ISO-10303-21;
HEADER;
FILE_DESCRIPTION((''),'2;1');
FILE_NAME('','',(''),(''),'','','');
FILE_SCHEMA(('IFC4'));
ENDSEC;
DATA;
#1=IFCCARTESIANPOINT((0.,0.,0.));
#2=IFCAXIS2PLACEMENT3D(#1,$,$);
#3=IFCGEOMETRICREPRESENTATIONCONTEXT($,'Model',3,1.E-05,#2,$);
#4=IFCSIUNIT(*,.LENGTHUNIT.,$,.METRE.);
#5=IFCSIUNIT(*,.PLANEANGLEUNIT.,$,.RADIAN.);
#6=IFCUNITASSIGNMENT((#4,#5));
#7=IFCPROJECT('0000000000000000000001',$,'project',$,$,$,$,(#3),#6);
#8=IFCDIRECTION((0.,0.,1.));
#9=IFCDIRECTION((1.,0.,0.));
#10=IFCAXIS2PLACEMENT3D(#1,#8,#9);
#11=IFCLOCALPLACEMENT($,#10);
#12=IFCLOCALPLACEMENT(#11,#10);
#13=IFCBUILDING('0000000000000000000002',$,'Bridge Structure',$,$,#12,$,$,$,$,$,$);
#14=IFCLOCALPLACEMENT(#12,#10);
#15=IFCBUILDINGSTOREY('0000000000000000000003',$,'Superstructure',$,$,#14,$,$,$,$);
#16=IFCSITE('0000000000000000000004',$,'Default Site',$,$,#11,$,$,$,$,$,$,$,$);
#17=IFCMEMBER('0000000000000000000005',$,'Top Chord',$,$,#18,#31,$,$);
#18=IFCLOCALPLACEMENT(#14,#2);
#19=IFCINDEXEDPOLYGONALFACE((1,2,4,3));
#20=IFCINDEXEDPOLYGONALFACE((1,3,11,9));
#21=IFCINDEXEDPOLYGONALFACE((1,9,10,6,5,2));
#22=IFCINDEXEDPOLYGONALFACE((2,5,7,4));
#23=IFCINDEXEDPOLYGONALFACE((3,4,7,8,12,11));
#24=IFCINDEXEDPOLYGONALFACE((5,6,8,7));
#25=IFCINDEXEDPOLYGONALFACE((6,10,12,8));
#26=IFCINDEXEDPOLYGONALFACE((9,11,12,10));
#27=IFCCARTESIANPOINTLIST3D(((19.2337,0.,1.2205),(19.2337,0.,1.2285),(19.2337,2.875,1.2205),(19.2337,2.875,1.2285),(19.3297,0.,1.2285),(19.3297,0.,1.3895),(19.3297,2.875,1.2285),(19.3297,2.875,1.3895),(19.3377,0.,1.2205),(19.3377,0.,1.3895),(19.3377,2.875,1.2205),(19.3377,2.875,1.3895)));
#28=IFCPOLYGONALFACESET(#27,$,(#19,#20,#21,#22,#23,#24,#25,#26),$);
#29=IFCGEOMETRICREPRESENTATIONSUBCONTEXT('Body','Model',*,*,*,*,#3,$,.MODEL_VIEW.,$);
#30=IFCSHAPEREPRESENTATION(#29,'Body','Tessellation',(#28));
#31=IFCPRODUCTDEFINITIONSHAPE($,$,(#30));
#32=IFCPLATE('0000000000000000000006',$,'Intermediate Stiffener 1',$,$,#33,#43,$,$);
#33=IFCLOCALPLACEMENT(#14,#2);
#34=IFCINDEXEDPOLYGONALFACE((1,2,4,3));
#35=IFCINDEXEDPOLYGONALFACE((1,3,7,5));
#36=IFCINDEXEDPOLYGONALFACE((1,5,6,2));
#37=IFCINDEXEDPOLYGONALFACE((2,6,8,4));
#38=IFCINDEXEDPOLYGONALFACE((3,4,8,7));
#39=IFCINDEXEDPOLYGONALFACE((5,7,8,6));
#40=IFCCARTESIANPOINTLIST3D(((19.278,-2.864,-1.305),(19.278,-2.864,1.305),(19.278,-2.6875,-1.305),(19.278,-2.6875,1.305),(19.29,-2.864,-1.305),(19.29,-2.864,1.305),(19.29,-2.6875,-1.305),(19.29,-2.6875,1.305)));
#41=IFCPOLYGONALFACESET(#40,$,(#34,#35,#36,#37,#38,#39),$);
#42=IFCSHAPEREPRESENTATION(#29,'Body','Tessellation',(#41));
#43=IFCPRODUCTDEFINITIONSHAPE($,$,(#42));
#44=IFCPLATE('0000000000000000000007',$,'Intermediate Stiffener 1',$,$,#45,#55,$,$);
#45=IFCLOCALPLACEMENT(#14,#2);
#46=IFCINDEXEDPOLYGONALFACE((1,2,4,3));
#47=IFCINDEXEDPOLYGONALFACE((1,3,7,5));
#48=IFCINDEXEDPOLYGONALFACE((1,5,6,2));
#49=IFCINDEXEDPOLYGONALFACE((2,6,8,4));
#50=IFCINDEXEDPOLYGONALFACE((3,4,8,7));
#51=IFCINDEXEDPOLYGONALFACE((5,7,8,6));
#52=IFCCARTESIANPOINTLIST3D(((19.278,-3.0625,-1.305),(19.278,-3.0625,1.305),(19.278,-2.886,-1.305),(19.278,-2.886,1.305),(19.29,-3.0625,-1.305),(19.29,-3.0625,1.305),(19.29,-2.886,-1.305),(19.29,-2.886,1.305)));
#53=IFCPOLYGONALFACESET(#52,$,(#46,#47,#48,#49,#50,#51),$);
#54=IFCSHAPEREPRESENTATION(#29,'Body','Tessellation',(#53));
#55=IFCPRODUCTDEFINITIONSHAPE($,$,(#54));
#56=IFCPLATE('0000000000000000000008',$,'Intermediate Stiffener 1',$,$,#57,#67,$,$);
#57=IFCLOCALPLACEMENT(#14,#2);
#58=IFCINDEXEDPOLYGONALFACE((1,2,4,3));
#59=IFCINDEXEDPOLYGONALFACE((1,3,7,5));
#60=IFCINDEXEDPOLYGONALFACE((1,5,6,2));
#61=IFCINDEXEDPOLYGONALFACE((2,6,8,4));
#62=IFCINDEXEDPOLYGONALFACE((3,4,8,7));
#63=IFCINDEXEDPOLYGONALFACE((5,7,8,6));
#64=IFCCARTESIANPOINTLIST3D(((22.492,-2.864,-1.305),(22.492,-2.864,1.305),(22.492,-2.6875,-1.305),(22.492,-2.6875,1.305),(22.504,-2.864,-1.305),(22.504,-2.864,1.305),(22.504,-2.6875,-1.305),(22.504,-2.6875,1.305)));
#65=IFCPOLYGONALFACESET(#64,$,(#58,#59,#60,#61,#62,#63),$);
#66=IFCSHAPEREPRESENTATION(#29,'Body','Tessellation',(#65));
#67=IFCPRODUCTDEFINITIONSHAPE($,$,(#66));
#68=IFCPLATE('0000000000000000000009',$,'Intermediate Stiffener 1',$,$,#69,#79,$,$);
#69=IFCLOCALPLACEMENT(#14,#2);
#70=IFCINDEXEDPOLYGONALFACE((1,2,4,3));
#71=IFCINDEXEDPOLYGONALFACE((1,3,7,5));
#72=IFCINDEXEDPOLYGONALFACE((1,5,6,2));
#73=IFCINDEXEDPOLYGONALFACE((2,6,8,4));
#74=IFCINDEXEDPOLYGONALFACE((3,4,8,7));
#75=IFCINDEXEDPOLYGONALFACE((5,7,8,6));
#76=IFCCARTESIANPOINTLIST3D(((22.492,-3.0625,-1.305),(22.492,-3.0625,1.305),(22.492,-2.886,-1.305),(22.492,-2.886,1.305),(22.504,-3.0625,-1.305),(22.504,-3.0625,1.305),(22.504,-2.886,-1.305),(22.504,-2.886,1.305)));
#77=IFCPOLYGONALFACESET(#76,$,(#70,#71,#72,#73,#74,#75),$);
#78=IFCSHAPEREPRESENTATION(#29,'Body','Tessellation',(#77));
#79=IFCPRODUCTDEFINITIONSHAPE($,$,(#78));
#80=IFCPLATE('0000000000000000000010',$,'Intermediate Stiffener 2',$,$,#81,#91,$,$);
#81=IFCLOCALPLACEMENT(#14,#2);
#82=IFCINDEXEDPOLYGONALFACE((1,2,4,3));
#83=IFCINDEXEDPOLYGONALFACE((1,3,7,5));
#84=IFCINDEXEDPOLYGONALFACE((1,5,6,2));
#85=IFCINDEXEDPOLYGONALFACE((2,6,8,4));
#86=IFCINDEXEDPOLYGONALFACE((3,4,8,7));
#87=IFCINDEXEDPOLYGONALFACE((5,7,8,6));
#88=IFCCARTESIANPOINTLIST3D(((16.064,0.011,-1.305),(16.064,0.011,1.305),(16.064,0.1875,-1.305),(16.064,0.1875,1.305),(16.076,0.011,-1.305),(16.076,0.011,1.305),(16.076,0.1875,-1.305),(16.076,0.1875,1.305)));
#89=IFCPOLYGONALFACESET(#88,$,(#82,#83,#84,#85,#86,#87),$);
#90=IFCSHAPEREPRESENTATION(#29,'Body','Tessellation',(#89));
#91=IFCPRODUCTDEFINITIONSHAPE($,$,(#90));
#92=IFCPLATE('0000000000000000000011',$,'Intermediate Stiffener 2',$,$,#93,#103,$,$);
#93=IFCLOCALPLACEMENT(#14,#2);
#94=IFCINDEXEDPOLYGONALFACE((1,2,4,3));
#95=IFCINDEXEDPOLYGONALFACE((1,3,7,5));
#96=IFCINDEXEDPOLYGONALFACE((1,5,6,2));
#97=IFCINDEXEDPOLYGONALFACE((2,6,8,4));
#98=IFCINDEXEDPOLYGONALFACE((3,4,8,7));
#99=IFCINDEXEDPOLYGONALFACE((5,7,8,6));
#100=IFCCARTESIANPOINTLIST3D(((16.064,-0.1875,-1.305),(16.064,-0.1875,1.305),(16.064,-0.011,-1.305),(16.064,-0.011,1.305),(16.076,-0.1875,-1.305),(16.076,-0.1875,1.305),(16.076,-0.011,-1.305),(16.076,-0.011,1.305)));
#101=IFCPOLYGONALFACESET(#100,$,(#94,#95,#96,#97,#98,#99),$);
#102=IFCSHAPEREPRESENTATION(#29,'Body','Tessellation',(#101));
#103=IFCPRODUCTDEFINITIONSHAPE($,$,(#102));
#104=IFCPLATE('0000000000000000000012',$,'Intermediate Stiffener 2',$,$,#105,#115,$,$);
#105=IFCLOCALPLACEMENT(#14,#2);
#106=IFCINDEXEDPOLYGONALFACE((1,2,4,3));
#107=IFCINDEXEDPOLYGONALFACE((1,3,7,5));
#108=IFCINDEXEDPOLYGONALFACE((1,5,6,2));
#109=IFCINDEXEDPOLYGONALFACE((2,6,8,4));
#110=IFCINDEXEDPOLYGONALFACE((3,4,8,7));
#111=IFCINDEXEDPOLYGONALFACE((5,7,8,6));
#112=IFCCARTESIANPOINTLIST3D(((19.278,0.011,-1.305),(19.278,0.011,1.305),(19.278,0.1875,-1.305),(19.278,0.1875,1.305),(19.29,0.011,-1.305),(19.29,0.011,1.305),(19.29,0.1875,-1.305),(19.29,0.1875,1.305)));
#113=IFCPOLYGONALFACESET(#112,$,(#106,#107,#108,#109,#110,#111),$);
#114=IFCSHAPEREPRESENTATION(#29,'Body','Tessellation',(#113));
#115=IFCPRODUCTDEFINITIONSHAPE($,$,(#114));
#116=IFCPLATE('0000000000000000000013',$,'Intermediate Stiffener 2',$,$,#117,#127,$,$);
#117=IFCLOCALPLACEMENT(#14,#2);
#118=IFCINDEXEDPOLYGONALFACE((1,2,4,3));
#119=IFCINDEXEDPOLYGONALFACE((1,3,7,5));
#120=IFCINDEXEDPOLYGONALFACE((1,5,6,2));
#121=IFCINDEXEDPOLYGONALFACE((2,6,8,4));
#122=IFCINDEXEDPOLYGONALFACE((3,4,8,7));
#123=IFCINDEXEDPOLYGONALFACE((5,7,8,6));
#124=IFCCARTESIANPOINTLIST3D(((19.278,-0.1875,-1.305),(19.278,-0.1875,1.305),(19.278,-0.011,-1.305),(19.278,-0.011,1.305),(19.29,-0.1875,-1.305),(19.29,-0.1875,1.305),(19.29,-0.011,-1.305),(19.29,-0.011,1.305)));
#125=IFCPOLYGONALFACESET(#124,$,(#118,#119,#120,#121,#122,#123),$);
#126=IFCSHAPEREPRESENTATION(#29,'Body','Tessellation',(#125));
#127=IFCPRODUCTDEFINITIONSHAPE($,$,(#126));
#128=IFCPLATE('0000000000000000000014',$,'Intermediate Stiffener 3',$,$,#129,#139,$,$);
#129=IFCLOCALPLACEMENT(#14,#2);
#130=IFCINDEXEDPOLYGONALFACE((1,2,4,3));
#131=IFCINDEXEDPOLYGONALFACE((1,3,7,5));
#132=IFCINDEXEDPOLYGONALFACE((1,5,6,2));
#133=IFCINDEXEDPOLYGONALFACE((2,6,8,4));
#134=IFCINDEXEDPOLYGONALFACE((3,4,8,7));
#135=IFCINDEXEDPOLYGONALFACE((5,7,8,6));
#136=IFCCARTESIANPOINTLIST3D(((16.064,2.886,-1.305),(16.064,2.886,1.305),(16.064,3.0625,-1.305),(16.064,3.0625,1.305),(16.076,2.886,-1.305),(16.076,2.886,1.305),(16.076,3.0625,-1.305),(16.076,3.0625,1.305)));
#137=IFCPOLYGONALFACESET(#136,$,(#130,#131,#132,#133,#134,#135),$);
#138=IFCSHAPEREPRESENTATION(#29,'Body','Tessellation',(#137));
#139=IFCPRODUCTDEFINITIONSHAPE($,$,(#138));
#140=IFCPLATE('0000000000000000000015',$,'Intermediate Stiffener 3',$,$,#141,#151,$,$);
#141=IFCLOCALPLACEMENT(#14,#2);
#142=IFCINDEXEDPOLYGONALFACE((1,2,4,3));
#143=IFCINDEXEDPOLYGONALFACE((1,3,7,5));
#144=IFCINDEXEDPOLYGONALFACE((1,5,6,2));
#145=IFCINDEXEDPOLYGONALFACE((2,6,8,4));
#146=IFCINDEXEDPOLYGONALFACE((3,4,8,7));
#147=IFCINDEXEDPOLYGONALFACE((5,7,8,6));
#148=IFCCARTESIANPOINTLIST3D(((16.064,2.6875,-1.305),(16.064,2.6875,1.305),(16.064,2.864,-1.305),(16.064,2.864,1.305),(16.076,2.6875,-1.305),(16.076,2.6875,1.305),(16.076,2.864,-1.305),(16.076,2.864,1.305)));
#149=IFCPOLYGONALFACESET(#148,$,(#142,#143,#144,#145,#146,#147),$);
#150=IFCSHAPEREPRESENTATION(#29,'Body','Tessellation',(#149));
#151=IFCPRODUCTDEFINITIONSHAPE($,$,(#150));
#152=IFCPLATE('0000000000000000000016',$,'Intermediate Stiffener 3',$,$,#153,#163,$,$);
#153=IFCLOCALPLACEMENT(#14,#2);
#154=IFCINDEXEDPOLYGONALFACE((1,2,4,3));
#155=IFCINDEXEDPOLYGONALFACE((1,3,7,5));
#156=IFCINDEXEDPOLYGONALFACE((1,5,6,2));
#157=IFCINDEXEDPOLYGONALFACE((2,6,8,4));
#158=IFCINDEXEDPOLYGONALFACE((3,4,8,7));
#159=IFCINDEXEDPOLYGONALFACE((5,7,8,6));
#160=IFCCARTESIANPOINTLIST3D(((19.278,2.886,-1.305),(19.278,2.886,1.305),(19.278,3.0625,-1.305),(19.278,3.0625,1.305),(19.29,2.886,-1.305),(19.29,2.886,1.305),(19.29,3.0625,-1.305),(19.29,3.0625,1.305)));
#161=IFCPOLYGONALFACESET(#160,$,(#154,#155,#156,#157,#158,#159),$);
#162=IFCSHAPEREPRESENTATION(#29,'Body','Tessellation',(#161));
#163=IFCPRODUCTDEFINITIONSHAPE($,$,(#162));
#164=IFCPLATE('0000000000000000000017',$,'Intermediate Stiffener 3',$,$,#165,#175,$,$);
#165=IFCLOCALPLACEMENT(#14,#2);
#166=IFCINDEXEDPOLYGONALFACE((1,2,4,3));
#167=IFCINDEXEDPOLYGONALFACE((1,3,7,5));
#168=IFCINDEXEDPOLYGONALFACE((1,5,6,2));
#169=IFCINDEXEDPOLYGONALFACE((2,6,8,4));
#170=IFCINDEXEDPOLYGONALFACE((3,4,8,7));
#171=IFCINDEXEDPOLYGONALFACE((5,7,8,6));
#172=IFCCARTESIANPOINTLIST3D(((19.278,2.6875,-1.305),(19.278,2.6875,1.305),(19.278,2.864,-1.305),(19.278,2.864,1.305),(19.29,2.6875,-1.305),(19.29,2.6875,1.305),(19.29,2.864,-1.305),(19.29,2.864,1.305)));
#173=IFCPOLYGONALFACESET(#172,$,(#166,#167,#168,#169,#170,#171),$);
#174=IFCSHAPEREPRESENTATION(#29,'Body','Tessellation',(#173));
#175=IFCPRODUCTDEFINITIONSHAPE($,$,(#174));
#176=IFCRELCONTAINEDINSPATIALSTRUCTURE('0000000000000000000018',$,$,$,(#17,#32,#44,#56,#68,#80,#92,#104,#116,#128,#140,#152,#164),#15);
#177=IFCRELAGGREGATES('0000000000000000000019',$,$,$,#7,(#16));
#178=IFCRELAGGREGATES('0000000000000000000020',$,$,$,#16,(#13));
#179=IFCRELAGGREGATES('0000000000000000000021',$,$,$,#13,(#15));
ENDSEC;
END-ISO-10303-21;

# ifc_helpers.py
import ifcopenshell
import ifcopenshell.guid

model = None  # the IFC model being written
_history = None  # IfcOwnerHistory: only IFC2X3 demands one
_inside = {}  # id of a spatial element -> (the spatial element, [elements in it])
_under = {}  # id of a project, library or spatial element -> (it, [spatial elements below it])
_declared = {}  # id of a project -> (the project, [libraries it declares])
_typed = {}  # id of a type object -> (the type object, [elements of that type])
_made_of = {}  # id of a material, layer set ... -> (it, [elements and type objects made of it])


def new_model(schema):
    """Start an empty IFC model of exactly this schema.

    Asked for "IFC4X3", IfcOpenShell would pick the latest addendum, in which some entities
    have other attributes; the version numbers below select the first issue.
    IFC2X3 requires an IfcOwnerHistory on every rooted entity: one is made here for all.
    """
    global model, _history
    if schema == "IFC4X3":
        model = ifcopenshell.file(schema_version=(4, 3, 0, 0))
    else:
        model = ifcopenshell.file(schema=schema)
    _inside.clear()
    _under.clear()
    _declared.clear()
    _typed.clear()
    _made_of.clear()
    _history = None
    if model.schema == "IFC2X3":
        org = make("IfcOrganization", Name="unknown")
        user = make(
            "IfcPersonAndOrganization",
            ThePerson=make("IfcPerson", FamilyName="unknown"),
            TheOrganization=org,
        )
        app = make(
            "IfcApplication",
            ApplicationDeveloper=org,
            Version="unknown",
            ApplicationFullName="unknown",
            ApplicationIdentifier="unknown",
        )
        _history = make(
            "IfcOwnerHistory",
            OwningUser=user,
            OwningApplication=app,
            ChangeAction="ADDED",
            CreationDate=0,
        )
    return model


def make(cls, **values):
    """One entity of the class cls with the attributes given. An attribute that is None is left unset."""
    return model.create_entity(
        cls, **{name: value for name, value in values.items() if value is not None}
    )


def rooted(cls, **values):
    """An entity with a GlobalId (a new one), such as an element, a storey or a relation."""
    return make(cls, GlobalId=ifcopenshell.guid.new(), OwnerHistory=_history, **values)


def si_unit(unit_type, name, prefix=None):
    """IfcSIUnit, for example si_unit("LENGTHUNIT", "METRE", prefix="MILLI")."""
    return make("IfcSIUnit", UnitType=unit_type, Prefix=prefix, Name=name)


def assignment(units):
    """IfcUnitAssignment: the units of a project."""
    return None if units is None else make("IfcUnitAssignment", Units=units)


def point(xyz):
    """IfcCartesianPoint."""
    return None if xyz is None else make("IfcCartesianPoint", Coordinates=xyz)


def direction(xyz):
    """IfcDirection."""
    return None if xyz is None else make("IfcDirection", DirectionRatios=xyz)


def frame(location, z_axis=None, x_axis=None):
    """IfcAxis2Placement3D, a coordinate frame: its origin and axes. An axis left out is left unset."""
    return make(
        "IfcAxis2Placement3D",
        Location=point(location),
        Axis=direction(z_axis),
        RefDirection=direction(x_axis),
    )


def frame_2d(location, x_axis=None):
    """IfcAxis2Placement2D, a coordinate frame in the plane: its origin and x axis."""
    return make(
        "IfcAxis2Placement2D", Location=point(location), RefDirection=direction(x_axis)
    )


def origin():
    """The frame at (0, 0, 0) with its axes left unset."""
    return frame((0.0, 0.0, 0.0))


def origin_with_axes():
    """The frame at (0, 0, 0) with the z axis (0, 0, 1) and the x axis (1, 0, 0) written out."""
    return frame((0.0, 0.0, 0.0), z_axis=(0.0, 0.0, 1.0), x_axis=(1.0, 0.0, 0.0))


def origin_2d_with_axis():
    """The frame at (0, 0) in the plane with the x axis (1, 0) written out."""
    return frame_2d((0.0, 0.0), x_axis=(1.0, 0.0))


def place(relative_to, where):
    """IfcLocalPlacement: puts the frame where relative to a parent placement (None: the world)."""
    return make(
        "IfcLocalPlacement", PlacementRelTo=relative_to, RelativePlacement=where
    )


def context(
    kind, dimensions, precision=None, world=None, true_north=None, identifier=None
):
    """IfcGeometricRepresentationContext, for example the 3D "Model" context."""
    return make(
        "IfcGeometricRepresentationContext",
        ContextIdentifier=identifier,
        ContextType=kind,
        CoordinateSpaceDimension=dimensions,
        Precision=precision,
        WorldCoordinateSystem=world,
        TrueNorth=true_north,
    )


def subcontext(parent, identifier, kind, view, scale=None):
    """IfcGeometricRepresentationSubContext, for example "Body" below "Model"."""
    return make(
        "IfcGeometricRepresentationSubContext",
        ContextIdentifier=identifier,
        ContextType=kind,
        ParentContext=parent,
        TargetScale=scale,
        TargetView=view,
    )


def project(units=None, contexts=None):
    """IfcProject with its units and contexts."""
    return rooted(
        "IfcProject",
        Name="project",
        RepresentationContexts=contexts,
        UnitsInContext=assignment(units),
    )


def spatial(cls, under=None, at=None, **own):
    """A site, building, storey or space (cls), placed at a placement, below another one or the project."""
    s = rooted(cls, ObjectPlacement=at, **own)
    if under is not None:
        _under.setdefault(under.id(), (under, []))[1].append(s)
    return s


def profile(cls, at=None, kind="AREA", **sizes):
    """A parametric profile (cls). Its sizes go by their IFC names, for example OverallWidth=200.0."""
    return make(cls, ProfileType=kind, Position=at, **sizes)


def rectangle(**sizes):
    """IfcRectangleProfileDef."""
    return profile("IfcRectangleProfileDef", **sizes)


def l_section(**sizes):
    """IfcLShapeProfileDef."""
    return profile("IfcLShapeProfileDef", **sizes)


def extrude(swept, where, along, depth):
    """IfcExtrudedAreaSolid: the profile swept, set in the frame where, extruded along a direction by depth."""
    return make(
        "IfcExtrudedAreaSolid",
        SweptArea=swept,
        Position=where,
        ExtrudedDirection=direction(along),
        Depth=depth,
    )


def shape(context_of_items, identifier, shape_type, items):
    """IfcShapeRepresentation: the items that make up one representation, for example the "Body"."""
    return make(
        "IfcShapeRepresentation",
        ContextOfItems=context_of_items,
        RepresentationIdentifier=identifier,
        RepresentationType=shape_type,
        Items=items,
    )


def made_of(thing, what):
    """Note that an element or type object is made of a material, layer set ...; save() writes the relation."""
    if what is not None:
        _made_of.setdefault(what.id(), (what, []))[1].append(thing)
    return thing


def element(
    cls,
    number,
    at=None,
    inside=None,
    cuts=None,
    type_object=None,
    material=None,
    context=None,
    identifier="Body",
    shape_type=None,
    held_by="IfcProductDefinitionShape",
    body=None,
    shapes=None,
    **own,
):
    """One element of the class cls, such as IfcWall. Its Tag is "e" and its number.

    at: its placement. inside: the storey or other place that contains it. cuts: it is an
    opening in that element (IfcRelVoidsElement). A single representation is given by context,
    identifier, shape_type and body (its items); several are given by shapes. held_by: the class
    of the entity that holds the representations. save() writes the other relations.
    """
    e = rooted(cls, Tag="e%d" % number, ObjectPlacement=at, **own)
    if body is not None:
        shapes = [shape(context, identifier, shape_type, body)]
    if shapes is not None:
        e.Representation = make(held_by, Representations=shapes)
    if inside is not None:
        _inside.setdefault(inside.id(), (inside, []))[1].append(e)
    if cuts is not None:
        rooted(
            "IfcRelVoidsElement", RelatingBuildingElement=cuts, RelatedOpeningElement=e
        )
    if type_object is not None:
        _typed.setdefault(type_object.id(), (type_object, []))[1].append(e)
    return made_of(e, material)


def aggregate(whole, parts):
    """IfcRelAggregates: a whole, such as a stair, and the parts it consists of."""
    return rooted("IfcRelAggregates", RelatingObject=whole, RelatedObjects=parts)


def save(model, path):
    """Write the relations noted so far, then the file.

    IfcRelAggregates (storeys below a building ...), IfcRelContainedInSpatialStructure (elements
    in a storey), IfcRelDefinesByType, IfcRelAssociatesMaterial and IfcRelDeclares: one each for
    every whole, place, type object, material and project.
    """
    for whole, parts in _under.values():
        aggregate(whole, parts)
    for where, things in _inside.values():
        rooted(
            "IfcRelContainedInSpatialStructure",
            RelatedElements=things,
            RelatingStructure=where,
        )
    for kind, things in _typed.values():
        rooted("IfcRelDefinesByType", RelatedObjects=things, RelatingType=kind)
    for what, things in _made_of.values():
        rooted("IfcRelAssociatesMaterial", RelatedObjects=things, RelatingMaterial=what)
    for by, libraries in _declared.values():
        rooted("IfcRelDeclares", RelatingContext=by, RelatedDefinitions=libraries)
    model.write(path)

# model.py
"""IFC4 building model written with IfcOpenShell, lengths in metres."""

from ifc_helpers import new_model, si_unit, frame, origin, origin_with_axes, origin_2d_with_axis, place, context, subcontext, project, spatial, rectangle, l_section, extrude, element, save


model = new_model("IFC4")

# Units and contexts
model_context = context("Model", 3, precision=1e-05, world=origin())
body_context = subcontext(model_context, "Body", "Model", "MODEL_VIEW")
ifc_project = project(units=[si_unit("LENGTHUNIT", "METRE"), si_unit("PLANEANGLEUNIT", "RADIAN")], contexts=[model_context])

# Site, building, storey
site_placement = place(None, origin_with_axes())
site = spatial("IfcSite", under=ifc_project, at=site_placement, Name="Default Site")
building_placement = place(site_placement, origin_with_axes())
building = spatial("IfcBuilding", under=site, at=building_placement, Name="Bridge Structure")
storey_placement = place(building_placement, origin_with_axes())
storey = spatial("IfcBuildingStorey", under=building, at=storey_placement, Name="Superstructure")

# Member
for number, where, z_axis, x_axis, name in (
    (1, (19.2857, 0.0, 1.305), (0.0, 1.0, 0.0), (-1.0, 0.0, 0.0), "Top Chord"),
):
    element("IfcMember", number, at=place(storey_placement, frame(where, z_axis=z_axis, x_axis=x_axis)), inside=storey, Name=name, context=body_context, shape_type="SweptSolid", body=[
        extrude(l_section(Depth=0.169, Width=0.104, Thickness=0.008, at=origin_2d_with_axis()), origin_with_axes(), (0.0, 0.0, 1.0), 2.875),
    ])

# Plates
for number, where, z_axis, x_axis, name in (
    (2, (19.284, -2.7757, -1.305), (0.0, 0.0, 1.0), (1.0, 0.0, 0.0), "Intermediate Stiffener 1"),
    (3, (19.284, -2.9743, -1.305), (0.0, 0.0, 1.0), (1.0, 0.0, 0.0), "Intermediate Stiffener 1"),
    (4, (22.498, -2.7757, -1.305), (0.0, 0.0, 1.0), (1.0, 0.0, 0.0), "Intermediate Stiffener 1"),
    (5, (22.498, -2.9743, -1.305), (0.0, 0.0, 1.0), (1.0, 0.0, 0.0), "Intermediate Stiffener 1"),
    (6, (16.07, 0.0993, -1.305), (0.0, 0.0, 1.0), (1.0, 0.0, 0.0), "Intermediate Stiffener 2"),
    (7, (16.07, -0.0993, -1.305), (0.0, 0.0, 1.0), (1.0, 0.0, 0.0), "Intermediate Stiffener 2"),
    (8, (19.284, 0.0993, -1.305), (0.0, 0.0, 1.0), (1.0, 0.0, 0.0), "Intermediate Stiffener 2"),
    (9, (19.284, -0.0993, -1.305), (0.0, 0.0, 1.0), (1.0, 0.0, 0.0), "Intermediate Stiffener 2"),
    (10, (16.07, 2.9743, -1.305), (0.0, 0.0, 1.0), (1.0, 0.0, 0.0), "Intermediate Stiffener 3"),
    (11, (16.07, 2.7757, -1.305), (0.0, 0.0, 1.0), (1.0, 0.0, 0.0), "Intermediate Stiffener 3"),
    (12, (19.284, 2.9743, -1.305), (0.0, 0.0, 1.0), (1.0, 0.0, 0.0), "Intermediate Stiffener 3"),
    (13, (19.284, 2.7757, -1.305), (0.0, 0.0, 1.0), (1.0, 0.0, 0.0), "Intermediate Stiffener 3"),
):
    element("IfcPlate", number, at=place(storey_placement, frame(where, z_axis=z_axis, x_axis=x_axis)), inside=storey, Name=name, context=body_context, shape_type="SweptSolid", body=[
        extrude(rectangle(XDim=0.012, YDim=0.1765, at=origin_2d_with_axis()), origin_with_axes(), (0.0, 0.0, 1.0), 2.61),
    ])

save(model, "model.ifc")
